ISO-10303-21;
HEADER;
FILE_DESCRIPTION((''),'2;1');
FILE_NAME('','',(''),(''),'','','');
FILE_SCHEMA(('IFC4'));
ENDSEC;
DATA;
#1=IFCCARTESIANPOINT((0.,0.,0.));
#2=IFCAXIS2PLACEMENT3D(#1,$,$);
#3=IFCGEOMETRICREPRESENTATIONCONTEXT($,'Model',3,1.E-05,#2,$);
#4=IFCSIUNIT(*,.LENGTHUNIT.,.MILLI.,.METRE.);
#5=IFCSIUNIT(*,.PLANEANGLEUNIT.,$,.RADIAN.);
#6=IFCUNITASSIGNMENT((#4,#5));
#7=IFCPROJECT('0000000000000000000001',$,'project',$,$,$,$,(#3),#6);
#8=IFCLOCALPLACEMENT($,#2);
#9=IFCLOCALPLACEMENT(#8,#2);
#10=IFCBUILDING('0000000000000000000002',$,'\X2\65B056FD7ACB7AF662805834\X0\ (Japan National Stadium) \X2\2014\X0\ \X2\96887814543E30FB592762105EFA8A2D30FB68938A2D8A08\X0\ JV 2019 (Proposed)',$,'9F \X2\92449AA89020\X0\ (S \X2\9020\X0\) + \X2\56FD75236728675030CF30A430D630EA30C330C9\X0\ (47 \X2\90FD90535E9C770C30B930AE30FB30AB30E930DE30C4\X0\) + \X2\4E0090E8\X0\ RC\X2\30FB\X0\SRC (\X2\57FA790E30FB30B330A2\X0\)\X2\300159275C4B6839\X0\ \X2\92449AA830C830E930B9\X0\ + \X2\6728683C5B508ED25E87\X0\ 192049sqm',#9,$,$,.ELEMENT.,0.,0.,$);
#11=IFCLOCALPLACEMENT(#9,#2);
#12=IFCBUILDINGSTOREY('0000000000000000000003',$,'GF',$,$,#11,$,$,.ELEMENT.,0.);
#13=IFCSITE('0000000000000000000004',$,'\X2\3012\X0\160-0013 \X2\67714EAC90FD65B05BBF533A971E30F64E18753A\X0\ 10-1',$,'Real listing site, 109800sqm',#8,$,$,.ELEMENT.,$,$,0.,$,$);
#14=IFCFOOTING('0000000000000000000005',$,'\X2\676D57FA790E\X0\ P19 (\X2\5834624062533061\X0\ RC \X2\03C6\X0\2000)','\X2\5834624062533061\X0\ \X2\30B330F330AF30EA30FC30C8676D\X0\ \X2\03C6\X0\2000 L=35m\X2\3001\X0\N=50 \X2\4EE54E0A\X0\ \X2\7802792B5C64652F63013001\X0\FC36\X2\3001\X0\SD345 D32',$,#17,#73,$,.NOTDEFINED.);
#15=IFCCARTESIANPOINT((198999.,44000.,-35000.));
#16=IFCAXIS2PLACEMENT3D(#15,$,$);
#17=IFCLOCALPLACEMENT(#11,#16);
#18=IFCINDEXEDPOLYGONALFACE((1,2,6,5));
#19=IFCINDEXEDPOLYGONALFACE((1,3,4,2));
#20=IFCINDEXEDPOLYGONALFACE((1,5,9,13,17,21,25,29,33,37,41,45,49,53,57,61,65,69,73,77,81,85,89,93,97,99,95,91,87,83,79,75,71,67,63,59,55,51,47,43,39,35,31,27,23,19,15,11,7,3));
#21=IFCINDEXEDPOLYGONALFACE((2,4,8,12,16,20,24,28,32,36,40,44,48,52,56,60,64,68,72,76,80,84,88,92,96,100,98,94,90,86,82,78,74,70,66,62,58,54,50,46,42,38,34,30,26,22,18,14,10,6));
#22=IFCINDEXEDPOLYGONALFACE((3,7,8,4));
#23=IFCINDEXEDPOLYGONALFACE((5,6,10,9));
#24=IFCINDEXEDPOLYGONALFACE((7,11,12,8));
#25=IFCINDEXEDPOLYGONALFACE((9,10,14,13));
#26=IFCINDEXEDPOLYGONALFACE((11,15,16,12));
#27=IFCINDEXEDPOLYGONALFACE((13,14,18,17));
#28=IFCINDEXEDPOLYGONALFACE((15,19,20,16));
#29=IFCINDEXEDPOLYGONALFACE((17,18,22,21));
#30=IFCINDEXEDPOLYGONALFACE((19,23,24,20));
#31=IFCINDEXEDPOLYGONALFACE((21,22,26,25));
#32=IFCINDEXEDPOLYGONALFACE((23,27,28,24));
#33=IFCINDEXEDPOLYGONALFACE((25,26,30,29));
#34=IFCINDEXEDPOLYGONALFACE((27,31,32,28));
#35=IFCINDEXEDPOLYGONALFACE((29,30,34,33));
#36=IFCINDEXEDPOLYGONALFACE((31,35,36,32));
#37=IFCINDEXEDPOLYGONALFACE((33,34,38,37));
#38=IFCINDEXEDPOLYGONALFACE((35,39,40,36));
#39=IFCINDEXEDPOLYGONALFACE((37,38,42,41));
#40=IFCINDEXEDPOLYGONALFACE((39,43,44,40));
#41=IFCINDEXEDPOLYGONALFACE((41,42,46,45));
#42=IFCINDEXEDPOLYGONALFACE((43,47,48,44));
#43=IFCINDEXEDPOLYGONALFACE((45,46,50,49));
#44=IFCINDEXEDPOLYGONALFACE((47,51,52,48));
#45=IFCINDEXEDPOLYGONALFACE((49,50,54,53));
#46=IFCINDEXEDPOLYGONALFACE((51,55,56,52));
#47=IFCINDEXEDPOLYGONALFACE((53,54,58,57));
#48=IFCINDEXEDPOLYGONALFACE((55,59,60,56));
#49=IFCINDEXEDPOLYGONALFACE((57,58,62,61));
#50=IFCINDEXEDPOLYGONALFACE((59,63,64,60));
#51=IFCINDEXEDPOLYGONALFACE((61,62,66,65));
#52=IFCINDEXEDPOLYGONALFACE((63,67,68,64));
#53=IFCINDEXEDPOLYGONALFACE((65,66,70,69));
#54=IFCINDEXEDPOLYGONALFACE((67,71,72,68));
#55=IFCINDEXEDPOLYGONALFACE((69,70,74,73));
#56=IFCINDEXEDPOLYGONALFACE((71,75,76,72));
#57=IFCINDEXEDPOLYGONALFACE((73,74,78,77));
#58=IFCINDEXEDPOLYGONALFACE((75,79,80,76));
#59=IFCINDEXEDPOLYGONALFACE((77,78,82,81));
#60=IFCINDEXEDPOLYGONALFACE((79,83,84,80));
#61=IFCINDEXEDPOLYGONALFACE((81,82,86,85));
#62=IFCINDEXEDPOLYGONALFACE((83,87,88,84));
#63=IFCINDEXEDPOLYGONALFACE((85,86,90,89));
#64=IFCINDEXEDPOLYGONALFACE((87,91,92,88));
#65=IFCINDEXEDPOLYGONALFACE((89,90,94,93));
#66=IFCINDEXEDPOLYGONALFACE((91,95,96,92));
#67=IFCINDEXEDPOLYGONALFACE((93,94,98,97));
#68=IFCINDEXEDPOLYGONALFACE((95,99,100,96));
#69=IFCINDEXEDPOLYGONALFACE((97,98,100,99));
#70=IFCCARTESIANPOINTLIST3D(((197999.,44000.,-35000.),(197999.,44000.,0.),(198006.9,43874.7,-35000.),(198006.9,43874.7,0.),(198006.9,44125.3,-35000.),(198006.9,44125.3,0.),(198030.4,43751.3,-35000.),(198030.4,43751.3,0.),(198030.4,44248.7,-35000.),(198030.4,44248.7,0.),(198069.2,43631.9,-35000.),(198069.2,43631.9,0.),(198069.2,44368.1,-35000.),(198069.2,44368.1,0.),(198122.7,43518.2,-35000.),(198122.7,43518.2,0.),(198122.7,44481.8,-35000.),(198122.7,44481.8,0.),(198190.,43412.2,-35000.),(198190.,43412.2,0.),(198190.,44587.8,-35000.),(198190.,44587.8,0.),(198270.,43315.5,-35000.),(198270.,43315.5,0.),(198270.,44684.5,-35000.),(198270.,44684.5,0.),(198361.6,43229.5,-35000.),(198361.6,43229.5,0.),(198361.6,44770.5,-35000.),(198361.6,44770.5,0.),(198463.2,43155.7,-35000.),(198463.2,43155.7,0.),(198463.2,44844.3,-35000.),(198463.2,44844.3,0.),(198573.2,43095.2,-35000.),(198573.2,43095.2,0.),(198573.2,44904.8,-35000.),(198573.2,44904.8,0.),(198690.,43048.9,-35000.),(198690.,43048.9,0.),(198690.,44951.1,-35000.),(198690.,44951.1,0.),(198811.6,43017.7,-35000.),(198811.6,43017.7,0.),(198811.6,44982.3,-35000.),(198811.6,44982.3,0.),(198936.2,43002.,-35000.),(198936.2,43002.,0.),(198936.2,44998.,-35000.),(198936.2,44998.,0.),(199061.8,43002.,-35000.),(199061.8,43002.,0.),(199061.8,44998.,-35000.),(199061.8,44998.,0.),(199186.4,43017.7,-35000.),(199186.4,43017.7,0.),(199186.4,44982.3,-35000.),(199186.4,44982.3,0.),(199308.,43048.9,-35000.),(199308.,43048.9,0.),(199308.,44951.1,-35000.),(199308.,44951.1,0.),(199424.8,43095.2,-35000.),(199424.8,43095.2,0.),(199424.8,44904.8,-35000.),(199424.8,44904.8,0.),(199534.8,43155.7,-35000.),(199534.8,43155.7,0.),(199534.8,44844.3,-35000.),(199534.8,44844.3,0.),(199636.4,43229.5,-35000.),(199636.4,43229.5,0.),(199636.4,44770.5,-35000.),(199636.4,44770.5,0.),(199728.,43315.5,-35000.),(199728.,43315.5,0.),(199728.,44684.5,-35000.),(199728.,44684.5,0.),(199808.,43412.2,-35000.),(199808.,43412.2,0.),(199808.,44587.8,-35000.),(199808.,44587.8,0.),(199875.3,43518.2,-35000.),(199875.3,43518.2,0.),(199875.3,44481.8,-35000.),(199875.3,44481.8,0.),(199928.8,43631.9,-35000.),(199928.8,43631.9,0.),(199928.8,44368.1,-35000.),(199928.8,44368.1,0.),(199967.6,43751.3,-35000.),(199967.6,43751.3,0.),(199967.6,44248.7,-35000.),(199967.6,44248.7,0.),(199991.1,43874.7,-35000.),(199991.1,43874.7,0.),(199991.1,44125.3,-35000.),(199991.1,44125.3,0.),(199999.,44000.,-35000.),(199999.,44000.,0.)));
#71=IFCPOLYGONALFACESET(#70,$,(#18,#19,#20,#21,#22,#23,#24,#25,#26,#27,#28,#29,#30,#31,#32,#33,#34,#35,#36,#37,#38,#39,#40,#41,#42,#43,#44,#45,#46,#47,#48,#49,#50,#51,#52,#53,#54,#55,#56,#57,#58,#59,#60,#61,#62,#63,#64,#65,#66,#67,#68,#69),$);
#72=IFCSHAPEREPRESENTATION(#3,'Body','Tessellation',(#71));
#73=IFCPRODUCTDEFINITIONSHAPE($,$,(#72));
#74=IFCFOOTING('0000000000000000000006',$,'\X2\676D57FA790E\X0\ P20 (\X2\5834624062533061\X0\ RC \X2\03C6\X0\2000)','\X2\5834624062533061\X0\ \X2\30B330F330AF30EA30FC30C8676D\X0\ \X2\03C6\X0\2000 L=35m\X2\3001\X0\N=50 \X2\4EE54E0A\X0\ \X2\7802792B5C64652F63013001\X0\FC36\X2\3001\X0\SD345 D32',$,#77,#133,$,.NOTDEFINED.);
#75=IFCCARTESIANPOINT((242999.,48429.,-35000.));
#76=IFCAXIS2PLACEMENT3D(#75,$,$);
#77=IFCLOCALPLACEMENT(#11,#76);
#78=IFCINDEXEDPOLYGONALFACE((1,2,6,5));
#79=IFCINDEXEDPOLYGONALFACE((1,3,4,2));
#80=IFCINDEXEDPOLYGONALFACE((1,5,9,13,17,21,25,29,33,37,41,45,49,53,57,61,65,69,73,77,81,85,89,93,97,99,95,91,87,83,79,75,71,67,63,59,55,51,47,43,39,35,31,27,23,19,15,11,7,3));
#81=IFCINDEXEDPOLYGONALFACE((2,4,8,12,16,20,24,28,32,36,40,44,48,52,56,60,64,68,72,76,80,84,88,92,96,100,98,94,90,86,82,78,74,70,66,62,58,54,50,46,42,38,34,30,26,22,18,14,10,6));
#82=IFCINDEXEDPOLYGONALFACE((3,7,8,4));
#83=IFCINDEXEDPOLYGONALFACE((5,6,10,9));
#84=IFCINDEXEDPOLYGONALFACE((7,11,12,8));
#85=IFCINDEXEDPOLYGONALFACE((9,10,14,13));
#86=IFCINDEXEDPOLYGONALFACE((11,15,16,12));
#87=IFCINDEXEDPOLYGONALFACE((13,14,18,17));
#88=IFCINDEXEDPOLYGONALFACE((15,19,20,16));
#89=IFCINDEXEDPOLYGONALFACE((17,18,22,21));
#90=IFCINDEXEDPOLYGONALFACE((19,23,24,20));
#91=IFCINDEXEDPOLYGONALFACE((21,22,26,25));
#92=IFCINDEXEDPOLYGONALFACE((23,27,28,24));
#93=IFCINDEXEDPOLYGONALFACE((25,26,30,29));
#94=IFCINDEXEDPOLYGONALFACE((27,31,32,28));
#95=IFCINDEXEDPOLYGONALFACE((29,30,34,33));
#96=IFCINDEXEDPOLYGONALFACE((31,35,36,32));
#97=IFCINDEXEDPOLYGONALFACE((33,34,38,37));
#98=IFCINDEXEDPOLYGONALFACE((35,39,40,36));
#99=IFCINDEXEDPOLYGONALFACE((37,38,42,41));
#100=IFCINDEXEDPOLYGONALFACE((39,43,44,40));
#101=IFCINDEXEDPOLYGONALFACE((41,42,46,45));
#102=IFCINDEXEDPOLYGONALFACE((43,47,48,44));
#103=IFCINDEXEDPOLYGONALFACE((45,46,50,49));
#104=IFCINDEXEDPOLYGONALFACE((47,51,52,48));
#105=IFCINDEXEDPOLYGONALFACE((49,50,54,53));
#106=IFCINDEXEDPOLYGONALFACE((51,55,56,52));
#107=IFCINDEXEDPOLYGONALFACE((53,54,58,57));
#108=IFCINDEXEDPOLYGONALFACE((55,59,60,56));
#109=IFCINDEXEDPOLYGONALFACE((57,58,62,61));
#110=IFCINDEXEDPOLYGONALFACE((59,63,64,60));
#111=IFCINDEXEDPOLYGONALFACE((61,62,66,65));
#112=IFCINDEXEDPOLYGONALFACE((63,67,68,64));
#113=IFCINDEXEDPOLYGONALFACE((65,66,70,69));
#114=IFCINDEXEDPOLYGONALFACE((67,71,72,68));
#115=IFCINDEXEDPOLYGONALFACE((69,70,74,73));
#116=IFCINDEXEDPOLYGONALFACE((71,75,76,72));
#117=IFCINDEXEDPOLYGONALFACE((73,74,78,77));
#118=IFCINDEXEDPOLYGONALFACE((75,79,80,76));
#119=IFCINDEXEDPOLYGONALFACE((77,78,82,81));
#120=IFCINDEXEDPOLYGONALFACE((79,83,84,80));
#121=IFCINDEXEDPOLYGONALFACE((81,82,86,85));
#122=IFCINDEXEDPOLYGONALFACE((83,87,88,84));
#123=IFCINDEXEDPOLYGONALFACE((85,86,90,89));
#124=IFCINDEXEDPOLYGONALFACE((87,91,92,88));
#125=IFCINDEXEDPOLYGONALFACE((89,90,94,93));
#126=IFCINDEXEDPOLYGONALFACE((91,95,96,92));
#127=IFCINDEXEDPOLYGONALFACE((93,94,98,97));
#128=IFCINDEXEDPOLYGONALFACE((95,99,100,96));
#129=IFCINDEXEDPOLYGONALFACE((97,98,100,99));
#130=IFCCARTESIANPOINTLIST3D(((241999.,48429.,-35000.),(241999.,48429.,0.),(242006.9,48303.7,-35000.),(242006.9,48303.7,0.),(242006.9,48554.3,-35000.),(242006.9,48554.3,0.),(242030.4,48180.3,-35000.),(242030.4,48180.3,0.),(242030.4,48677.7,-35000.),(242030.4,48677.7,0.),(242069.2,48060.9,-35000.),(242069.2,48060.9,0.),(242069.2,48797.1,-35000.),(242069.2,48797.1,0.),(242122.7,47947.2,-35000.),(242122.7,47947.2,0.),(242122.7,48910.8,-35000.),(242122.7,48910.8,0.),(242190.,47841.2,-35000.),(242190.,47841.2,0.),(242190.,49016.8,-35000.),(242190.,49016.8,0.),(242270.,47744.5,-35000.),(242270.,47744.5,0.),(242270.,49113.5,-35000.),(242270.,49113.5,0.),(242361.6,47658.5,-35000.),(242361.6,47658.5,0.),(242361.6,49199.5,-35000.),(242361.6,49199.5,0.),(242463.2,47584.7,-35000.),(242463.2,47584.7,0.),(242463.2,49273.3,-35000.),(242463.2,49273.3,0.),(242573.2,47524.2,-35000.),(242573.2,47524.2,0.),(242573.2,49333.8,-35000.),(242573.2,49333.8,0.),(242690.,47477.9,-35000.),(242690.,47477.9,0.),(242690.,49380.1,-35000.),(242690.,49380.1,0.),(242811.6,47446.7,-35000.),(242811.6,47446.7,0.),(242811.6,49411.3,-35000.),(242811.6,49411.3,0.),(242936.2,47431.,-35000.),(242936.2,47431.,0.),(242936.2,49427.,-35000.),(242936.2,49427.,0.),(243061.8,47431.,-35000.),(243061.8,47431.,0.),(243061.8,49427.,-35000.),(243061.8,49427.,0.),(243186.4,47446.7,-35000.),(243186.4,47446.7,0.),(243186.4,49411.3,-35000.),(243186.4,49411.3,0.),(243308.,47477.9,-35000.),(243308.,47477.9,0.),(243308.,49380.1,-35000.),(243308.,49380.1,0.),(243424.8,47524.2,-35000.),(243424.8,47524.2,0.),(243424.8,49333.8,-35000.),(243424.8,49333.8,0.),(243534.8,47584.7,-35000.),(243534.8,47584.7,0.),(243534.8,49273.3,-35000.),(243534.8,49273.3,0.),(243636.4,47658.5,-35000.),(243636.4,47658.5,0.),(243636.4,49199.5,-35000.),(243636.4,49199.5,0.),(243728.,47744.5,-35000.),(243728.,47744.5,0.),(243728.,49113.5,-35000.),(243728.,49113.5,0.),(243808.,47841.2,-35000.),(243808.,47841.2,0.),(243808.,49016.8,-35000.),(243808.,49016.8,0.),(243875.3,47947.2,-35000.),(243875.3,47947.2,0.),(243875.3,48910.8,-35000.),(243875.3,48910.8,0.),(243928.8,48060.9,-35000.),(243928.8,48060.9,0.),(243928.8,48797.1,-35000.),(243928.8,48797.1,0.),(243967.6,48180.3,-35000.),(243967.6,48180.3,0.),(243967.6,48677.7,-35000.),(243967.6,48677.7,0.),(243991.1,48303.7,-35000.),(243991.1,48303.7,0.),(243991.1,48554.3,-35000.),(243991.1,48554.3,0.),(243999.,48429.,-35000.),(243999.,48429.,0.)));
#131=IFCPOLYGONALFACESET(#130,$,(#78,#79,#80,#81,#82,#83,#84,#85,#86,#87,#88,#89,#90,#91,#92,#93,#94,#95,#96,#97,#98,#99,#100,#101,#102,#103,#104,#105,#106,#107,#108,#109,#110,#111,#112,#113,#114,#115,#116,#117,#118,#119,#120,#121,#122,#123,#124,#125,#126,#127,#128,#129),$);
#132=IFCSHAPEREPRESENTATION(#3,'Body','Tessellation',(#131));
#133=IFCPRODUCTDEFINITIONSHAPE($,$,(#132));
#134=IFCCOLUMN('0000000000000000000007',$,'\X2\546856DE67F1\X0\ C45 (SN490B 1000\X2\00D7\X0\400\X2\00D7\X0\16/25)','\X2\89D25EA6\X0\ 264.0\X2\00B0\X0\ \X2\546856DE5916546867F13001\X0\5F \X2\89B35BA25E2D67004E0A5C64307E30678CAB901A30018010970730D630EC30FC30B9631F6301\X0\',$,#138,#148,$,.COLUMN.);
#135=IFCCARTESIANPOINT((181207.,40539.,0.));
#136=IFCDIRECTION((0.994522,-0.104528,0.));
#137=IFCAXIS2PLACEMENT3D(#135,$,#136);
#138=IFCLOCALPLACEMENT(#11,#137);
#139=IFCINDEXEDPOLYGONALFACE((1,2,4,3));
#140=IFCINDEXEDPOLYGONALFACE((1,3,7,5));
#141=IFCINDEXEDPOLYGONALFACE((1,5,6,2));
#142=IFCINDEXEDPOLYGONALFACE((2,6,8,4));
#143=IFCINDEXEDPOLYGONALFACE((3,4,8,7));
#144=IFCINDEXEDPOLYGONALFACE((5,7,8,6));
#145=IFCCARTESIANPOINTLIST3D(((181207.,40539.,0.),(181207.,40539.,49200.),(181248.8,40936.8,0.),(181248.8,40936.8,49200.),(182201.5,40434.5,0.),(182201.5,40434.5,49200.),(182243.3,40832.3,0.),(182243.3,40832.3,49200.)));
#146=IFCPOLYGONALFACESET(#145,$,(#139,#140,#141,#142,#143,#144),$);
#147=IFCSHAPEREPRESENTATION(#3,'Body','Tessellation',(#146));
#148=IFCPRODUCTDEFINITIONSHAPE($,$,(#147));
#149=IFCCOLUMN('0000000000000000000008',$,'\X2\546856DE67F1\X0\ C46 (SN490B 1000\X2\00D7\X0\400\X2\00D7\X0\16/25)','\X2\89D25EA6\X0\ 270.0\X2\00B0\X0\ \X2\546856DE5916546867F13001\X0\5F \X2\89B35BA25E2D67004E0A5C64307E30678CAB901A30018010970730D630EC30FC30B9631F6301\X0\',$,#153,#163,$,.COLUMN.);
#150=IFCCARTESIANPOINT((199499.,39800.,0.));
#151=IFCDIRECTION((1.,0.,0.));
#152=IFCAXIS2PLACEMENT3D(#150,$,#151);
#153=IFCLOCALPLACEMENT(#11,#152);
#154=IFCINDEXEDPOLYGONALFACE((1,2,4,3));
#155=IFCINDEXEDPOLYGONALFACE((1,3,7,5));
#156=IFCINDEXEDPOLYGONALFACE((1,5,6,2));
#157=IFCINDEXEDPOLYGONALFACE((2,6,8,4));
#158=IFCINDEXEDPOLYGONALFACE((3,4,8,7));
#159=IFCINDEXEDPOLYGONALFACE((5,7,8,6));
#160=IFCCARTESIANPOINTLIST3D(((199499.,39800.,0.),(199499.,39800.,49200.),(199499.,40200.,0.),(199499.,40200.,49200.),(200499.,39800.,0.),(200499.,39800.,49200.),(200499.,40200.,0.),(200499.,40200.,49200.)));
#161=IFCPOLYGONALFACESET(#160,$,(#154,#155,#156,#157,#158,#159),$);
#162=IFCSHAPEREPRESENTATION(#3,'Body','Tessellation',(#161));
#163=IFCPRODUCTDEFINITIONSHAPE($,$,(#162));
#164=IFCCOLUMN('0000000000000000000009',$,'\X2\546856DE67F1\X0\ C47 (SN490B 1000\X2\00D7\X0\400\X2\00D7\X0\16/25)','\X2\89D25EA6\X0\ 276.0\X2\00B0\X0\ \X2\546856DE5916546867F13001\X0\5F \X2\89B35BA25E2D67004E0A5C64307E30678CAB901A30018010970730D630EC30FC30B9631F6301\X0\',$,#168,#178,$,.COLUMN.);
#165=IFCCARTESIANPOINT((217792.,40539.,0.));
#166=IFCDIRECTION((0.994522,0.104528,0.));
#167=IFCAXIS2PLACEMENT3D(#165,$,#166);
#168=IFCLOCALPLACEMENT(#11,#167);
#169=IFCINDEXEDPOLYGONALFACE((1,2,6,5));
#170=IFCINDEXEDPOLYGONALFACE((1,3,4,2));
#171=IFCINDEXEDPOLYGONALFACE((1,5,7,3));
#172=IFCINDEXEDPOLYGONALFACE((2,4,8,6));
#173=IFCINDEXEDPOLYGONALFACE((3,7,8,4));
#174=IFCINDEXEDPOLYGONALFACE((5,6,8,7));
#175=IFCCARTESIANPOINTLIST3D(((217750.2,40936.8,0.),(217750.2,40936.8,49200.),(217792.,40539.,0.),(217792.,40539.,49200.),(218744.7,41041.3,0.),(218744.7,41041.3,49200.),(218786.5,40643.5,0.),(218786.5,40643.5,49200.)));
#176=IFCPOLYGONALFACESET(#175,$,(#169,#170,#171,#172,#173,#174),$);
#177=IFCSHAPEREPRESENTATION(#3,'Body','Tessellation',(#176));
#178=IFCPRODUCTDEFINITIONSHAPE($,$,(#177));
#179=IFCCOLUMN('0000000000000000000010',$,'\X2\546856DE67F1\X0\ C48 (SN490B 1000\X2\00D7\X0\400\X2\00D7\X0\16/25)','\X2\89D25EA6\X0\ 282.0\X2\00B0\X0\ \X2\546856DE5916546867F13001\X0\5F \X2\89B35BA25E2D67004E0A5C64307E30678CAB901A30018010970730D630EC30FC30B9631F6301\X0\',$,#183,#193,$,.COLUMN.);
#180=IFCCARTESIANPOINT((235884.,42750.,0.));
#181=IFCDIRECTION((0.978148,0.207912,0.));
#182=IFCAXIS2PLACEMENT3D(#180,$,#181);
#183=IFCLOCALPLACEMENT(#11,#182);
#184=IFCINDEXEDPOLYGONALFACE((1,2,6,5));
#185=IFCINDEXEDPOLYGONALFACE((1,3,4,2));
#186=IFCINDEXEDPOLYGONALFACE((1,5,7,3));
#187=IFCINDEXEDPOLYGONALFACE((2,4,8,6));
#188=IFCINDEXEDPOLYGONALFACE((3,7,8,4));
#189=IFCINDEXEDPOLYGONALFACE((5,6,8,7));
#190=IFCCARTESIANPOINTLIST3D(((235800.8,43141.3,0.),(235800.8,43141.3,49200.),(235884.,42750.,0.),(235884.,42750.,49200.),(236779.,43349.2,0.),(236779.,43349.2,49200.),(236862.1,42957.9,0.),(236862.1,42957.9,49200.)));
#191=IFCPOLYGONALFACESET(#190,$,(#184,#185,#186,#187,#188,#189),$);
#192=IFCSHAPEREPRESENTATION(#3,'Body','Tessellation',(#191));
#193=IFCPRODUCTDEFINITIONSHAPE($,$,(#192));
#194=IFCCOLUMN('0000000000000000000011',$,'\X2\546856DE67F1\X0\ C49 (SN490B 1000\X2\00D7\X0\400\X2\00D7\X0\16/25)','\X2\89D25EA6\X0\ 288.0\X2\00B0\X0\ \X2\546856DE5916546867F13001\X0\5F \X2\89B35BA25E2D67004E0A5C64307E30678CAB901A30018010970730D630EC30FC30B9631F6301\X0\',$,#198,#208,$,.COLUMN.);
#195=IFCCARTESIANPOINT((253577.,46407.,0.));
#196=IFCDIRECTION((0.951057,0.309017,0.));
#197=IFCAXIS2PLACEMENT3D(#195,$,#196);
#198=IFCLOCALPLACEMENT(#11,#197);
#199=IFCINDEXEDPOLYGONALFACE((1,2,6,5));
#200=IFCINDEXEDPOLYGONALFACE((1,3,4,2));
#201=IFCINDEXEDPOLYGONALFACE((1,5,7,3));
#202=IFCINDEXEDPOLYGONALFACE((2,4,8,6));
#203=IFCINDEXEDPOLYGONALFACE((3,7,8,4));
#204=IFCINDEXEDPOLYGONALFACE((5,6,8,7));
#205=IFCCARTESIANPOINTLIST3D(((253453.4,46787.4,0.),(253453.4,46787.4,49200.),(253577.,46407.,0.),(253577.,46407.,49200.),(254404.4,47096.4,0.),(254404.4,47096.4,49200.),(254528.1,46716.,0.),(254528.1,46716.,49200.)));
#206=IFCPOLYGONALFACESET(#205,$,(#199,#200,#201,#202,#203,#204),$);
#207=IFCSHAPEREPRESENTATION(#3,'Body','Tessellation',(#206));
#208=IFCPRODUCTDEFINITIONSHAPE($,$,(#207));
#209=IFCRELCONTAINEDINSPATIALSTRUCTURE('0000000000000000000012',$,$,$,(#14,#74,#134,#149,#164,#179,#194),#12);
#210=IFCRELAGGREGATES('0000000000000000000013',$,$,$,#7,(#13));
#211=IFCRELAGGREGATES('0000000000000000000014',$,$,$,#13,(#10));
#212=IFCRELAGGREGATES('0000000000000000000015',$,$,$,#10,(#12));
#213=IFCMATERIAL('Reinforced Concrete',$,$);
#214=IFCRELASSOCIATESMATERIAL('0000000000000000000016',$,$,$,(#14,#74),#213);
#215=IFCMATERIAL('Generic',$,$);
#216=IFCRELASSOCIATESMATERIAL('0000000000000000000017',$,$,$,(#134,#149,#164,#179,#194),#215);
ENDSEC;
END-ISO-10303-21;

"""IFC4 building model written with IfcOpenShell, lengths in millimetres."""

from ifc_helpers import new_model, si_unit, frame, frame_2d, origin, origin_2d, place, context, project, spatial, rectangle, circle, extrude, material, element, save


model = new_model("IFC4")

# Units and contexts
model_context = context("Model", 3, precision=1e-05, world=origin())
ifc_project = project(units=[si_unit("LENGTHUNIT", "METRE", prefix="MILLI"), si_unit("PLANEANGLEUNIT", "RADIAN")], contexts=[model_context])

# Site, building, storey
site_placement = place(None, origin())
site = spatial("IfcSite", under=ifc_project, at=site_placement, Name="〒160-0013 東京都新宿区霞ヶ丘町 10-1", ObjectType="Real listing site, 109800sqm", CompositionType="ELEMENT", RefElevation=0.0)
building_placement = place(site_placement, origin())
building = spatial("IfcBuilding", under=site, at=building_placement, Name="新国立競技場 (Japan National Stadium) — 隈研吾・大成建設・梓設計 JV 2019 (Proposed)", ObjectType="9F 鉄骨造 (S 造) + 国産木材ハイブリッド (47 都道府県スギ・カラマツ) + 一部 RC・SRC (基礎・コア)、大屋根 鉄骨トラス + 木格子軒庇 192049sqm", CompositionType="ELEMENT", ElevationOfRefHeight=0.0, ElevationOfTerrain=0.0)
storey_placement = place(building_placement, origin())
storey = spatial("IfcBuildingStorey", under=building, at=storey_placement, Name="GF", CompositionType="ELEMENT", Elevation=0.0)

# Footings
ifc_material_1 = material(Name="Reinforced Concrete")
footing_1_placement = place(storey_placement, frame((198999.0, 44000.0, -35000.0)))
element("IfcFooting", 1, at=footing_1_placement, inside=storey, material=ifc_material_1, Name="杭基礎 P19 (場所打ち RC φ2000)", Description="場所打ち コンクリート杭 φ2000 L=35m、N=50 以上 砂礫層支持、FC36、SD345 D32", PredefinedType="NOTDEFINED", context=model_context, shape_type="SweptSolid", body=[
    extrude(circle(Radius=1000.0, at=origin_2d()), frame((198999.0, 44000.0, -35000.0)), (0.0, 0.0, 1.0), 35000.0),
])
footing_2_placement = place(storey_placement, frame((242999.0, 48429.0, -35000.0)))
element("IfcFooting", 2, at=footing_2_placement, inside=storey, material=ifc_material_1, Name="杭基礎 P20 (場所打ち RC φ2000)", Description="場所打ち コンクリート杭 φ2000 L=35m、N=50 以上 砂礫層支持、FC36、SD345 D32", PredefinedType="NOTDEFINED", context=model_context, shape_type="SweptSolid", body=[
    extrude(circle(Radius=1000.0, at=origin_2d()), frame((242999.0, 48429.0, -35000.0)), (0.0, 0.0, 1.0), 35000.0),
])

# Columns
ifc_material_2 = material(Name="Generic")
column_1_placement = place(storey_placement, frame((181207.0, 40539.0, 0.0), x_axis=(0.994522, -0.104528, 0.0)))
element("IfcColumn", 3, at=column_1_placement, inside=storey, material=ifc_material_2, Name="周回柱 C45 (SN490B 1000×400×16/25)", Description="角度 264.0° 周回外周柱、5F 観客席最上層まで貫通、耐震ブレース挟持", PredefinedType="COLUMN", context=model_context, shape_type="SweptSolid", body=[
    extrude(rectangle(XDim=1000.0, YDim=400.0, at=frame_2d((500.0, 200.0))), frame((181207.0, 40539.0, 0.0), x_axis=(0.994522, -0.104528, 0.0)), (0.0, 0.0, 1.0), 49200.0),
])
column_2_placement = place(storey_placement, frame((199499.0, 39800.0, 0.0), x_axis=(1.0, 0.0, 0.0)))
element("IfcColumn", 4, at=column_2_placement, inside=storey, material=ifc_material_2, Name="周回柱 C46 (SN490B 1000×400×16/25)", Description="角度 270.0° 周回外周柱、5F 観客席最上層まで貫通、耐震ブレース挟持", PredefinedType="COLUMN", context=model_context, shape_type="SweptSolid", body=[
    extrude(rectangle(XDim=1000.0, YDim=400.0, at=frame_2d((500.0, 200.0))), frame((199499.0, 39800.0, 0.0), x_axis=(1.0, 0.0, 0.0)), (0.0, 0.0, 1.0), 49200.0),
])
column_3_placement = place(storey_placement, frame((217792.0, 40539.0, 0.0), x_axis=(0.994522, 0.104528, 0.0)))
element("IfcColumn", 5, at=column_3_placement, inside=storey, material=ifc_material_2, Name="周回柱 C47 (SN490B 1000×400×16/25)", Description="角度 276.0° 周回外周柱、5F 観客席最上層まで貫通、耐震ブレース挟持", PredefinedType="COLUMN", context=model_context, shape_type="SweptSolid", body=[
    extrude(rectangle(XDim=1000.0, YDim=400.0, at=frame_2d((500.0, 200.0))), frame((217792.0, 40539.0, 0.0), x_axis=(0.994522, 0.104528, 0.0)), (0.0, 0.0, 1.0), 49200.0),
])
column_4_placement = place(storey_placement, frame((235884.0, 42750.0, 0.0), x_axis=(0.978148, 0.207912, 0.0)))
element("IfcColumn", 6, at=column_4_placement, inside=storey, material=ifc_material_2, Name="周回柱 C48 (SN490B 1000×400×16/25)", Description="角度 282.0° 周回外周柱、5F 観客席最上層まで貫通、耐震ブレース挟持", PredefinedType="COLUMN", context=model_context, shape_type="SweptSolid", body=[
    extrude(rectangle(XDim=1000.0, YDim=400.0, at=frame_2d((500.0, 200.0))), frame((235884.0, 42750.0, 0.0), x_axis=(0.978148, 0.207912, 0.0)), (0.0, 0.0, 1.0), 49200.0),
])
column_5_placement = place(storey_placement, frame((253577.0, 46407.0, 0.0), x_axis=(0.951057, 0.309017, 0.0)))
element("IfcColumn", 7, at=column_5_placement, inside=storey, material=ifc_material_2, Name="周回柱 C49 (SN490B 1000×400×16/25)", Description="角度 288.0° 周回外周柱、5F 観客席最上層まで貫通、耐震ブレース挟持", PredefinedType="COLUMN", context=model_context, shape_type="SweptSolid", body=[
    extrude(rectangle(XDim=1000.0, YDim=400.0, at=frame_2d((500.0, 200.0))), frame((253577.0, 46407.0, 0.0), x_axis=(0.951057, 0.309017, 0.0)), (0.0, 0.0, 1.0), 49200.0),
])

save(model, "model.ifc")
